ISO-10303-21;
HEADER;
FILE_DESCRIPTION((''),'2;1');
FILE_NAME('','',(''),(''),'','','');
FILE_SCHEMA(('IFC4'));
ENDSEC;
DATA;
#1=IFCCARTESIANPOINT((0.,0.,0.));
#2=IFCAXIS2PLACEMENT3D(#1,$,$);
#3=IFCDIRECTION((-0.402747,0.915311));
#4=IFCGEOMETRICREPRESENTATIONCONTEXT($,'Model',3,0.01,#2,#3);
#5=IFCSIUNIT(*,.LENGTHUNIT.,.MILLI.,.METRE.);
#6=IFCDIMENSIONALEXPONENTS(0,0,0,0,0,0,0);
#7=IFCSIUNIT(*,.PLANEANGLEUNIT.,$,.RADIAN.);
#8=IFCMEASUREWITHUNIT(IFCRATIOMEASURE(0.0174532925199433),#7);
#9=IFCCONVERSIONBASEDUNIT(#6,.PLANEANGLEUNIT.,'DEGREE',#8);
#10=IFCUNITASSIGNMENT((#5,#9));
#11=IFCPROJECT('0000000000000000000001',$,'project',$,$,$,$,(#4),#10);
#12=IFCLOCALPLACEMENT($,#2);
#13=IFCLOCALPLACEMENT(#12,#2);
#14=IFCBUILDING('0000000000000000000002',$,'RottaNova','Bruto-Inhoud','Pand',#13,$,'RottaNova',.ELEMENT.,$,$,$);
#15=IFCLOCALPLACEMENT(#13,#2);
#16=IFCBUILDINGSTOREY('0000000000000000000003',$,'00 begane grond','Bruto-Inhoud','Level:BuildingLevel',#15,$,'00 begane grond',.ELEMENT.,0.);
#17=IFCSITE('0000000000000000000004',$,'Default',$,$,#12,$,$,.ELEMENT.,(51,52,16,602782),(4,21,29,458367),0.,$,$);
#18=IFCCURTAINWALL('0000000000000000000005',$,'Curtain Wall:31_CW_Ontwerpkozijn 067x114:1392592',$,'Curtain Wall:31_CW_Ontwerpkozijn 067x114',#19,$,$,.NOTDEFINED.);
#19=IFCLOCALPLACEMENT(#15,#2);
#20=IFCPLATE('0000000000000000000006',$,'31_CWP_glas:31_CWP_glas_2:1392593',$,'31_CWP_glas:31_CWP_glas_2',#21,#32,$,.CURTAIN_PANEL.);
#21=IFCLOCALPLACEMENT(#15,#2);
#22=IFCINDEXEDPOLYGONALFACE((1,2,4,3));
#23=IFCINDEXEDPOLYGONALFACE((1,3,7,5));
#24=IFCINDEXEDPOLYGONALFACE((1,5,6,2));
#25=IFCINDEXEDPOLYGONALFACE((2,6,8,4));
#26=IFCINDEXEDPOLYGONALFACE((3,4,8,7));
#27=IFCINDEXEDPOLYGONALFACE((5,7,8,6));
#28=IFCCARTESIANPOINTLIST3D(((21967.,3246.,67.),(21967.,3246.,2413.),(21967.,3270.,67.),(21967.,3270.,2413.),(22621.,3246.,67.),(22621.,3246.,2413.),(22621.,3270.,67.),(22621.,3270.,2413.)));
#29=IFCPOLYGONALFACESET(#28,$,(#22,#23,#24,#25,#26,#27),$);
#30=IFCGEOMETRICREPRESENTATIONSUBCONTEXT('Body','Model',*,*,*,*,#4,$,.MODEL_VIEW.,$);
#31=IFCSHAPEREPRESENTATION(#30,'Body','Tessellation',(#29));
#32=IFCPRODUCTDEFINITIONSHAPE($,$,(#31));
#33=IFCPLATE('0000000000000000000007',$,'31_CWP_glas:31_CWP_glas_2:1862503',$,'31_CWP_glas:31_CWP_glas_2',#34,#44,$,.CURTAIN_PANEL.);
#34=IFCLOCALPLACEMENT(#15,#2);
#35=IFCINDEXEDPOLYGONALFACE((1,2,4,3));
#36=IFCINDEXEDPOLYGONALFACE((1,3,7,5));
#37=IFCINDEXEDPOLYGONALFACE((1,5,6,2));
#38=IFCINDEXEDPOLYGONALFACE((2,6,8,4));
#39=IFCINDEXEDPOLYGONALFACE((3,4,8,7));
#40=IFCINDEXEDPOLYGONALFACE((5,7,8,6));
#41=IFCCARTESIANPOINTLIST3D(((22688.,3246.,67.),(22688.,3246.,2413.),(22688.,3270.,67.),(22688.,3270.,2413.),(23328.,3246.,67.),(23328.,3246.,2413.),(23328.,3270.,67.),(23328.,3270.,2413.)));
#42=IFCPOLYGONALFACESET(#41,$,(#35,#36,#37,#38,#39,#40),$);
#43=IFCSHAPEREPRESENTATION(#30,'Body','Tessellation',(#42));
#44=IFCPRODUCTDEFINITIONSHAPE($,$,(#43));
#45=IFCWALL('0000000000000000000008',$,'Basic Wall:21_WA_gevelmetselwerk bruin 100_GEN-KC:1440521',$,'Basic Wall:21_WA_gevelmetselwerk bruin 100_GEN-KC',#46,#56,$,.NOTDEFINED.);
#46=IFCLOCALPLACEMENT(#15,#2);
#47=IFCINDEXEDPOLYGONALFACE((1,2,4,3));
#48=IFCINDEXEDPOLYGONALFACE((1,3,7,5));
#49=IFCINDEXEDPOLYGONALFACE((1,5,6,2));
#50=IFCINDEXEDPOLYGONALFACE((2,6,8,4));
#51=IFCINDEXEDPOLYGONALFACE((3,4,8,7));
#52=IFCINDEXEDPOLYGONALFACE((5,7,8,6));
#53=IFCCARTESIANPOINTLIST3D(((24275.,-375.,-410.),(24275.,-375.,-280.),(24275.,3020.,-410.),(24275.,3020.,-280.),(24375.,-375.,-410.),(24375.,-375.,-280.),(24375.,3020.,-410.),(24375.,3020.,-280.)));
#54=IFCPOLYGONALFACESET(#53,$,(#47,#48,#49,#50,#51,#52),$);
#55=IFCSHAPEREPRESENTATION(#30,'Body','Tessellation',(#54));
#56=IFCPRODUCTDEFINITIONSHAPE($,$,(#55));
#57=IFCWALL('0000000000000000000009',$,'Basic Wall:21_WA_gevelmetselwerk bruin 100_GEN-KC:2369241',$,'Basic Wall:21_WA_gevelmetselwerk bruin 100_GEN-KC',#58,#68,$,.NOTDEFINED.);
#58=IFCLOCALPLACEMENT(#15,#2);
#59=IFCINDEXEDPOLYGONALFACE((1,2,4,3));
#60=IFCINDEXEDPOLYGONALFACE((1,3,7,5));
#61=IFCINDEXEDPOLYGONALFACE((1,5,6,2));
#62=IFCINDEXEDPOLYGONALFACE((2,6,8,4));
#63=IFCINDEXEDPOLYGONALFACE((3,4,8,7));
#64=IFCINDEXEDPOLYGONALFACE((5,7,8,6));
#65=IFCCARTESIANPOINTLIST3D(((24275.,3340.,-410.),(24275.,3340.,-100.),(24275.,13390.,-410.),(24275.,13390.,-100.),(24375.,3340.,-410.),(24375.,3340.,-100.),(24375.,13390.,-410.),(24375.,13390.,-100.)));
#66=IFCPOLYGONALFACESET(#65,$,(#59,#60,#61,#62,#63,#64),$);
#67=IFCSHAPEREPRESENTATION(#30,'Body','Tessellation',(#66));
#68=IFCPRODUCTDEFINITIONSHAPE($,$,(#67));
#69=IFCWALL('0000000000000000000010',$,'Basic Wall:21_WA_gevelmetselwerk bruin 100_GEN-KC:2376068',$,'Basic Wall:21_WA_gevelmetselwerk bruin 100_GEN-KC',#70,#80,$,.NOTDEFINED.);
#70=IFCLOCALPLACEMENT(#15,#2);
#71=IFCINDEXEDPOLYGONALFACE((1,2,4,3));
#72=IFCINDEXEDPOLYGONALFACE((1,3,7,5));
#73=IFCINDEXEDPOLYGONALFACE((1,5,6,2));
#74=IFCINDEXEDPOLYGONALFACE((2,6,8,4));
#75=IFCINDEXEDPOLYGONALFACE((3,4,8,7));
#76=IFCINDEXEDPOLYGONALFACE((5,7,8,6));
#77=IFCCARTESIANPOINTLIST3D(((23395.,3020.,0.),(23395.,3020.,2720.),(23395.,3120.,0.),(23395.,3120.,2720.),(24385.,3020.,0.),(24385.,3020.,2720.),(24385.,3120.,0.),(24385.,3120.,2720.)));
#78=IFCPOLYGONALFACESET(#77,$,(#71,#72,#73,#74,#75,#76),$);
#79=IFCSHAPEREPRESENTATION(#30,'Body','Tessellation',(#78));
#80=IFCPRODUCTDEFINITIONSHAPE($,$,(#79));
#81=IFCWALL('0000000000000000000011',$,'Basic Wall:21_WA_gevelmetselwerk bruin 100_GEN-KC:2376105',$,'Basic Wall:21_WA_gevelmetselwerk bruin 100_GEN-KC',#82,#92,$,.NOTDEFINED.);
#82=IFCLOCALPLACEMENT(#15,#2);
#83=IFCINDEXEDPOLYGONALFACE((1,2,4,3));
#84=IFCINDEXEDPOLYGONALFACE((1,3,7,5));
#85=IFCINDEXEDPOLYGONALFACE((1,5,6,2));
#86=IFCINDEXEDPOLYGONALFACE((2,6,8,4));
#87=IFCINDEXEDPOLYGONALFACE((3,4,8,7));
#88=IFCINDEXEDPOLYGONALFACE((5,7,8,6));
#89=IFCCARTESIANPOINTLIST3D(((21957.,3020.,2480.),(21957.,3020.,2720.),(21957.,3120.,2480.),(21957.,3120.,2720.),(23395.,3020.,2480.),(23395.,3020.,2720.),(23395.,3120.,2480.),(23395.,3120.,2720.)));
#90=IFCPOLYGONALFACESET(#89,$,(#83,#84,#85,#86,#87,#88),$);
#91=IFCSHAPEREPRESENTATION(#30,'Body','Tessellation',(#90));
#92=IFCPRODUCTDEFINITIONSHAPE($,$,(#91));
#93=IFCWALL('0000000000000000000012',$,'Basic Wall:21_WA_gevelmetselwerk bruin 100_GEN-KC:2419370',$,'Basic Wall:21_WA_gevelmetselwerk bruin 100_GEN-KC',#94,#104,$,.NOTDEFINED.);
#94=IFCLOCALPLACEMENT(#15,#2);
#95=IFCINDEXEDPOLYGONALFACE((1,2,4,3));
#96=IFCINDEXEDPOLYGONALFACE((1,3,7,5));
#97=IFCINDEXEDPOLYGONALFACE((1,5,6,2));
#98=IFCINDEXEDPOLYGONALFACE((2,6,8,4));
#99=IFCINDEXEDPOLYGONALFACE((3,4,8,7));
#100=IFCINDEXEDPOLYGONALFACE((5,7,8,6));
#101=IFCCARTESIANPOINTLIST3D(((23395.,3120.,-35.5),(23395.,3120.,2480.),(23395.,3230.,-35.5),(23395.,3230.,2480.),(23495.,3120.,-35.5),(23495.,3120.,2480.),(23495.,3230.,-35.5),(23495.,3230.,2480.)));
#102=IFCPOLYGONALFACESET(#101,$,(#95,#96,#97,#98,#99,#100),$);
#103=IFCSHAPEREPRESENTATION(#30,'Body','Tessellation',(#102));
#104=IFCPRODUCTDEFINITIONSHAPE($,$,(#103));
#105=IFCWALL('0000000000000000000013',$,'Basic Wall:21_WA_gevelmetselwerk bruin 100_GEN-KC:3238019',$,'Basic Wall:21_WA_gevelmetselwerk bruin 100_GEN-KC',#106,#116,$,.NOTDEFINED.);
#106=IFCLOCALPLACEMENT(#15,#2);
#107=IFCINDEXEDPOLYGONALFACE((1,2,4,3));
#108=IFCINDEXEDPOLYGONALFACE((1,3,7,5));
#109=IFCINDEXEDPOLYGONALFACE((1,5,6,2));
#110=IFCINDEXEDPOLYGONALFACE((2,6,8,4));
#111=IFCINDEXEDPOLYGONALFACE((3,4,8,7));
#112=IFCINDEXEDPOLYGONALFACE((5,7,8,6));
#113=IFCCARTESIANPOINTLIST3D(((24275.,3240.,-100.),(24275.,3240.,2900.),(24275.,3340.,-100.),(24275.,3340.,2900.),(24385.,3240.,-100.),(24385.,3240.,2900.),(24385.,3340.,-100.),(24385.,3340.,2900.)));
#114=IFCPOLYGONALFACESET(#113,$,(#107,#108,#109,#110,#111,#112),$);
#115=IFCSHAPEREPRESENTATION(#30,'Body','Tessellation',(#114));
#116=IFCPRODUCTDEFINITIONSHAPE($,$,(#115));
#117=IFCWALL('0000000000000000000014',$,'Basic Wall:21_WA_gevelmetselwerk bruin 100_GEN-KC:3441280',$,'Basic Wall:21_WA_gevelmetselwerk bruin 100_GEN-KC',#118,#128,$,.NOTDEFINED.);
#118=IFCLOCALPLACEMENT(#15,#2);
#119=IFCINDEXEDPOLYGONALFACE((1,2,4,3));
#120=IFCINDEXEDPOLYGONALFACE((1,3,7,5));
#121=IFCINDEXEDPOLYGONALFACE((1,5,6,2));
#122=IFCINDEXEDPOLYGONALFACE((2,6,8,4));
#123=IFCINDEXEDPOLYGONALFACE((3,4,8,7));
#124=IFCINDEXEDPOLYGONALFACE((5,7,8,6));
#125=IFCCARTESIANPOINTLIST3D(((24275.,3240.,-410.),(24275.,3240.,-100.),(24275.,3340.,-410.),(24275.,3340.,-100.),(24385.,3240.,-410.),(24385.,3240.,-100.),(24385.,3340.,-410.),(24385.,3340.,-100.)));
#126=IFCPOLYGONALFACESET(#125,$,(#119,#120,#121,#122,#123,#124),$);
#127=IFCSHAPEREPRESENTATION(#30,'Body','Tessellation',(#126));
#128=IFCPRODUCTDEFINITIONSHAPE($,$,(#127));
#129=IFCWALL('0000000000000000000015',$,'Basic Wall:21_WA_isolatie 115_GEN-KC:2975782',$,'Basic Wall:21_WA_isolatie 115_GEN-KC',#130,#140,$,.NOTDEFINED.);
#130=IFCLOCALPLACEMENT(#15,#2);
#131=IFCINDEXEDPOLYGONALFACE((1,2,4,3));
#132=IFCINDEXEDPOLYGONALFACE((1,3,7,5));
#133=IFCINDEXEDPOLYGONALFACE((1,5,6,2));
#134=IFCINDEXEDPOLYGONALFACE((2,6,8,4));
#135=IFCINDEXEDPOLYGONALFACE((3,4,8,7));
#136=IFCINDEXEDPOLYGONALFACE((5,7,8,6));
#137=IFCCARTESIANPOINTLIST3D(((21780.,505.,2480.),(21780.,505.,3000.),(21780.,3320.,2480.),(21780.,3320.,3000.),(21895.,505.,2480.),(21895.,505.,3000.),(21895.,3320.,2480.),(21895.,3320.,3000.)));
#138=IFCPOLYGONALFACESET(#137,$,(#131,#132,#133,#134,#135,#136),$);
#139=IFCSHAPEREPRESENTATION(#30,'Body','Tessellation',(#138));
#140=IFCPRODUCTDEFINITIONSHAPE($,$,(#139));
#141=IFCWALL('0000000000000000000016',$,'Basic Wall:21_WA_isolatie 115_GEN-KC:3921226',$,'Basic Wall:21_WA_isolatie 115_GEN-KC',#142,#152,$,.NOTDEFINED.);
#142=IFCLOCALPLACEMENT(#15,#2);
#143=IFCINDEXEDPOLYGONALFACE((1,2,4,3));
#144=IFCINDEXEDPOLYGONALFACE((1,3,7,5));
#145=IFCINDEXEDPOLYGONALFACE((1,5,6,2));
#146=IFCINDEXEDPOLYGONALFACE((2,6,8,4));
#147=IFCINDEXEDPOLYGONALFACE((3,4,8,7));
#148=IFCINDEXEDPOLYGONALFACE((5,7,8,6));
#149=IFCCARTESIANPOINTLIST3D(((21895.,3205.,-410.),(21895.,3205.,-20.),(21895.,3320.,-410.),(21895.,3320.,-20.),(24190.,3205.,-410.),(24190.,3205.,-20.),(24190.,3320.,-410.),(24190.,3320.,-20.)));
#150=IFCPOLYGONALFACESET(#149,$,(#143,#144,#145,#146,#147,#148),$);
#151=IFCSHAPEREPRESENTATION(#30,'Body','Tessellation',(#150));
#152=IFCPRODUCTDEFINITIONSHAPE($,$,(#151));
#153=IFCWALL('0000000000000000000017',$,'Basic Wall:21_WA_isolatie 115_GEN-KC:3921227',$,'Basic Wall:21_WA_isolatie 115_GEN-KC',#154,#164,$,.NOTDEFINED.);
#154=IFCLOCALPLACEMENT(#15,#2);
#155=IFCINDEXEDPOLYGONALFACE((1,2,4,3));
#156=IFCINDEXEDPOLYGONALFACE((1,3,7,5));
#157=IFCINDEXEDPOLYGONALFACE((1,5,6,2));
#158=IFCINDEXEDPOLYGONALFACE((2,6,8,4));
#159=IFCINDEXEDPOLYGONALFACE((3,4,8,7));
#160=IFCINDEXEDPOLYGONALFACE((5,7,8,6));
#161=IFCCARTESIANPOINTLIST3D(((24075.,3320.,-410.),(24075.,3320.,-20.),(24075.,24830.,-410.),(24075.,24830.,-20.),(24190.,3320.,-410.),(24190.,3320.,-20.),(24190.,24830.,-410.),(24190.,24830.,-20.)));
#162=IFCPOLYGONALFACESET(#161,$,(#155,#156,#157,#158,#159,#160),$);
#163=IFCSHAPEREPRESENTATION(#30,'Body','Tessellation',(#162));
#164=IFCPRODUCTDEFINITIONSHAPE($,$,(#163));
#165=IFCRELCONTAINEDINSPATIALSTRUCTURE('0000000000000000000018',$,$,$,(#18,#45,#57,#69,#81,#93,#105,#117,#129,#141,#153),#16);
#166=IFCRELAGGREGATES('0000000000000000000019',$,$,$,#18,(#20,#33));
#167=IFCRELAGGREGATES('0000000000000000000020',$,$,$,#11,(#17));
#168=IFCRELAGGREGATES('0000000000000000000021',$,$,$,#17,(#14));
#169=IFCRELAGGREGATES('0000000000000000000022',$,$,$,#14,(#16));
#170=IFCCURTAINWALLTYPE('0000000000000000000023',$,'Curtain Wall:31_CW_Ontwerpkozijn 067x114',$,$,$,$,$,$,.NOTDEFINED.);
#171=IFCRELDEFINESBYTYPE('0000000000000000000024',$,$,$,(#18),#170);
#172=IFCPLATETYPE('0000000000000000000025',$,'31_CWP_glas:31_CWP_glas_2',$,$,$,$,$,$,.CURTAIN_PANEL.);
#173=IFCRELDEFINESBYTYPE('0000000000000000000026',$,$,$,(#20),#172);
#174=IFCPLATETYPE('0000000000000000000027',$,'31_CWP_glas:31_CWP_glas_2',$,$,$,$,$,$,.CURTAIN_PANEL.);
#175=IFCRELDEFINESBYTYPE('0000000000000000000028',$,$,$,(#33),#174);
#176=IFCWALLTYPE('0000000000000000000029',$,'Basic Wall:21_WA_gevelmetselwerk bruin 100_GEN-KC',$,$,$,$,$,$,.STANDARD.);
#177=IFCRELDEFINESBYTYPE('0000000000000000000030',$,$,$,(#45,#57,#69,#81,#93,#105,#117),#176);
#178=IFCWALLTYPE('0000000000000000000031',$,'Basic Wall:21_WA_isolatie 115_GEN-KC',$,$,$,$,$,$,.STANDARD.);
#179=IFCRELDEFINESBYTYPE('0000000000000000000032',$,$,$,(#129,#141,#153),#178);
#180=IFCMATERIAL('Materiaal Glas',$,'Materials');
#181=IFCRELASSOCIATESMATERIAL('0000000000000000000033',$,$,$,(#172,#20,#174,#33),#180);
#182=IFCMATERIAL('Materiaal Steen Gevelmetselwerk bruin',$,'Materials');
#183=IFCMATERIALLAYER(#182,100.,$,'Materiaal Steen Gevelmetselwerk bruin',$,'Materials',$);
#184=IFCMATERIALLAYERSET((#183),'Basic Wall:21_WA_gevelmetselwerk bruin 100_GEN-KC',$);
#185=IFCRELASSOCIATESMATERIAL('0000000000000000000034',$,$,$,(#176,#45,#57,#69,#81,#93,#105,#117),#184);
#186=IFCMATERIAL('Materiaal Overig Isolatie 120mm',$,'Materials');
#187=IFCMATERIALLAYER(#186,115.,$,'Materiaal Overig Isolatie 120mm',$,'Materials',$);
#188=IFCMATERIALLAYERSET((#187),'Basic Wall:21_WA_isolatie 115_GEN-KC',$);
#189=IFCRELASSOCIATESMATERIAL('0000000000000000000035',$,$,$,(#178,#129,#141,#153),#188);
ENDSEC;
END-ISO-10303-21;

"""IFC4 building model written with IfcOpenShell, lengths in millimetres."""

from ifc_helpers import new_model, entity, si_unit, converted_unit, direction, frame, frame_2d, origin, place, context, subcontext, project, spatial, rectangle, extrude, source, transform, mapped, material, layer, layer_set, type_object, type_shapes, element, aggregate, save


model = new_model("IFC4")

# Units and contexts
model_context = context("Model", 3, precision=0.01, world=origin(), true_north=direction((-0.402747, 0.915311)))
body_context = subcontext(model_context, "Body", "Model", "MODEL_VIEW")
ifc_project = project(units=[si_unit("LENGTHUNIT", "METRE", prefix="MILLI"), converted_unit("PLANEANGLEUNIT", "DEGREE", entity("IfcRatioMeasure", 0.0174532925199433), si_unit("PLANEANGLEUNIT", "RADIAN"), dimensions=[0, 0, 0, 0, 0, 0, 0])], contexts=[model_context])

# Site, building, storey
site_placement = place(None, origin())
site = spatial("IfcSite", under=ifc_project, at=site_placement, Name="Default", CompositionType="ELEMENT", RefLatitude=(51, 52, 16, 602782), RefLongitude=(4, 21, 29, 458367), RefElevation=0.0)
building_placement = place(site_placement, origin())
building = spatial("IfcBuilding", under=site, at=building_placement, Name="RottaNova", Description="Bruto-Inhoud", ObjectType="Pand", LongName="RottaNova", CompositionType="ELEMENT")
storey_placement = place(building_placement, origin())
storey = spatial("IfcBuildingStorey", under=building, at=storey_placement, Name="00 begane grond", Description="Bruto-Inhoud", ObjectType="Level:BuildingLevel", LongName="00 begane grond", CompositionType="ELEMENT", Elevation=0.0)

# Curtain wall
curtain_wall_type = type_object("IfcCurtainWallType", Name="Curtain Wall:31_CW_Ontwerpkozijn 067x114", PredefinedType="NOTDEFINED")
curtain_wall_1_placement = place(storey_placement, origin())
curtain_wall_1 = element("IfcCurtainWall", 1, at=curtain_wall_1_placement, inside=storey, type_object=curtain_wall_type, Name="Curtain Wall:31_CW_Ontwerpkozijn 067x114:1392592", ObjectType="Curtain Wall:31_CW_Ontwerpkozijn 067x114", PredefinedType="NOTDEFINED")

# Plates
ifc_material_1 = material(Name="Materiaal Glas", Category="Materials")
plate_type_1 = type_object("IfcPlateType", Name="31_CWP_glas:31_CWP_glas_2", PredefinedType="CURTAIN_PANEL", material=ifc_material_1)
shared_shape_1 = source(origin(), body_context, "Body", "SweptSolid", [
    extrude(rectangle(XDim=24.0, YDim=654.0, at=frame_2d((0.0, 0.0), x_axis=(1.0, 0.0))), frame((327.0, 12.0, 0.0), z_axis=(0.0, 0.0, 1.0), x_axis=(0.0, 1.0, 0.0)), (0.0, 0.0, 1.0), 2346.0),
])
type_shapes(plate_type_1, [shared_shape_1])
plate_1_placement = place(curtain_wall_1_placement, frame((21967.0, 3246.0, 67.0)))
plate_1 = element("IfcPlate", 2, at=plate_1_placement, type_object=plate_type_1, material=ifc_material_1, Name="31_CWP_glas:31_CWP_glas_2:1392593", ObjectType="31_CWP_glas:31_CWP_glas_2", PredefinedType="CURTAIN_PANEL", context=body_context, shape_type="MappedRepresentation", body=[
    mapped(shared_shape_1, transform((0.0, 0.0, 0.0), scale=1.0)),
])
plate_type_2 = type_object("IfcPlateType", Name="31_CWP_glas:31_CWP_glas_2", PredefinedType="CURTAIN_PANEL", material=ifc_material_1)
shared_shape_2 = source(origin(), body_context, "Body", "SweptSolid", [
    extrude(rectangle(XDim=24.0, YDim=640.0, at=frame_2d((0.0, 0.0), x_axis=(1.0, 0.0))), frame((320.0, 12.0, 0.0), z_axis=(0.0, 0.0, 1.0), x_axis=(0.0, 1.0, 0.0)), (0.0, 0.0, 1.0), 2346.0),
])
type_shapes(plate_type_2, [shared_shape_2])
plate_2_placement = place(curtain_wall_1_placement, frame((22688.0, 3246.0, 67.0)))
plate_2 = element("IfcPlate", 3, at=plate_2_placement, type_object=plate_type_2, material=ifc_material_1, Name="31_CWP_glas:31_CWP_glas_2:1862503", ObjectType="31_CWP_glas:31_CWP_glas_2", PredefinedType="CURTAIN_PANEL", context=body_context, shape_type="MappedRepresentation", body=[
    mapped(shared_shape_2, transform((0.0, 0.0, 0.0), scale=1.0)),
])
aggregate(curtain_wall_1, [plate_1, plate_2])

# Walls
ifc_material_2 = material(Name="Materiaal Steen Gevelmetselwerk bruin", Category="Materials")
ifc_layer_1 = layer(ifc_material_2, 100.0, Name="Materiaal Steen Gevelmetselwerk bruin", Category="Materials")
ifc_layer_set_1 = layer_set([ifc_layer_1], Name="Basic Wall:21_WA_gevelmetselwerk bruin 100_GEN-KC")
wall_type_1 = type_object("IfcWallType", Name="Basic Wall:21_WA_gevelmetselwerk bruin 100_GEN-KC", PredefinedType="STANDARD", material=ifc_layer_set_1)
wall_1_placement = place(storey_placement, frame((24325.0, 3020.0, -410.0), z_axis=(0.0, 0.0, 1.0), x_axis=(0.0, -1.0, 0.0)))
element("IfcWall", 4, at=wall_1_placement, inside=storey, type_object=wall_type_1, material=ifc_layer_set_1, Name="Basic Wall:21_WA_gevelmetselwerk bruin 100_GEN-KC:1440521", ObjectType="Basic Wall:21_WA_gevelmetselwerk bruin 100_GEN-KC", PredefinedType="NOTDEFINED", context=body_context, shape_type="SweptSolid", body=[
    extrude(rectangle(XDim=3395.0, YDim=100.0, at=frame_2d((1697.5, 0.0), x_axis=(-1.0, 0.0))), origin(), (0.0, 0.0, 1.0), 130.0),
])
wall_2_placement = place(storey_placement, frame((24325.0, 3340.0, -410.0), z_axis=(0.0, 0.0, 1.0), x_axis=(0.0, 1.0, 0.0)))
element("IfcWall", 5, at=wall_2_placement, inside=storey, type_object=wall_type_1, material=ifc_layer_set_1, Name="Basic Wall:21_WA_gevelmetselwerk bruin 100_GEN-KC:2369241", ObjectType="Basic Wall:21_WA_gevelmetselwerk bruin 100_GEN-KC", PredefinedType="NOTDEFINED", context=body_context, shape_type="SweptSolid", body=[
    extrude(rectangle(XDim=10050.0, YDim=100.0, at=frame_2d((5025.0, 0.0), x_axis=(-1.0, 0.0))), origin(), (0.0, 0.0, 1.0), 310.0),
])
wall_3_placement = place(storey_placement, frame((23395.0, 3070.0, 0.0)))
element("IfcWall", 6, at=wall_3_placement, inside=storey, type_object=wall_type_1, material=ifc_layer_set_1, Name="Basic Wall:21_WA_gevelmetselwerk bruin 100_GEN-KC:2376068", ObjectType="Basic Wall:21_WA_gevelmetselwerk bruin 100_GEN-KC", PredefinedType="NOTDEFINED", context=body_context, shape_type="SweptSolid", body=[
    extrude(rectangle(XDim=990.0, YDim=100.0, at=frame_2d((495.0, 0.0), x_axis=(-1.0, 0.0))), origin(), (0.0, 0.0, 1.0), 2720.0),
])
wall_4_placement = place(storey_placement, frame((23395.0, 3070.0, 2480.0), z_axis=(0.0, 0.0, 1.0), x_axis=(-1.0, 0.0, 0.0)))
element("IfcWall", 7, at=wall_4_placement, inside=storey, type_object=wall_type_1, material=ifc_layer_set_1, Name="Basic Wall:21_WA_gevelmetselwerk bruin 100_GEN-KC:2376105", ObjectType="Basic Wall:21_WA_gevelmetselwerk bruin 100_GEN-KC", PredefinedType="NOTDEFINED", context=body_context, shape_type="SweptSolid", body=[
    extrude(rectangle(XDim=1438.0, YDim=100.0, at=frame_2d((719.0, 0.0), x_axis=(-1.0, 0.0))), origin(), (0.0, 0.0, 1.0), 240.0),
])
wall_5_placement = place(storey_placement, frame((23445.0, 3230.0, -35.5), z_axis=(0.0, 0.0, 1.0), x_axis=(0.0, -1.0, 0.0)))
element("IfcWall", 8, at=wall_5_placement, inside=storey, type_object=wall_type_1, material=ifc_layer_set_1, Name="Basic Wall:21_WA_gevelmetselwerk bruin 100_GEN-KC:2419370", ObjectType="Basic Wall:21_WA_gevelmetselwerk bruin 100_GEN-KC", PredefinedType="NOTDEFINED", context=body_context, shape_type="SweptSolid", body=[
    extrude(rectangle(XDim=110.0, YDim=100.0, at=frame_2d((55.0, 0.0), x_axis=(-1.0, 0.0))), origin(), (0.0, 0.0, 1.0), 2515.5),
])
wall_6_placement = place(storey_placement, frame((24385.0, 3290.0, -100.0), z_axis=(0.0, 0.0, 1.0), x_axis=(-1.0, 0.0, 0.0)))
element("IfcWall", 9, at=wall_6_placement, inside=storey, type_object=wall_type_1, material=ifc_layer_set_1, Name="Basic Wall:21_WA_gevelmetselwerk bruin 100_GEN-KC:3238019", ObjectType="Basic Wall:21_WA_gevelmetselwerk bruin 100_GEN-KC", PredefinedType="NOTDEFINED", context=body_context, shape_type="SweptSolid", body=[
    extrude(rectangle(XDim=110.0, YDim=100.0, at=frame_2d((55.0, 0.0), x_axis=(-1.0, 0.0))), origin(), (0.0, 0.0, 1.0), 3000.0),
])
wall_7_placement = place(storey_placement, frame((24385.0, 3290.0, -410.0), z_axis=(0.0, 0.0, 1.0), x_axis=(-1.0, 0.0, 0.0)))
element("IfcWall", 10, at=wall_7_placement, inside=storey, type_object=wall_type_1, material=ifc_layer_set_1, Name="Basic Wall:21_WA_gevelmetselwerk bruin 100_GEN-KC:3441280", ObjectType="Basic Wall:21_WA_gevelmetselwerk bruin 100_GEN-KC", PredefinedType="NOTDEFINED", context=body_context, shape_type="SweptSolid", body=[
    extrude(rectangle(XDim=110.0, YDim=100.0, at=frame_2d((55.0, 0.0), x_axis=(-1.0, 0.0))), origin(), (0.0, 0.0, 1.0), 310.0),
])

# Shared definitions
ifc_material_3 = material(Name="Materiaal Overig Isolatie 120mm", Category="Materials")
ifc_layer_2 = layer(ifc_material_3, 115.0, Name="Materiaal Overig Isolatie 120mm", Category="Materials")
ifc_layer_set_2 = layer_set([ifc_layer_2], Name="Basic Wall:21_WA_isolatie 115_GEN-KC")
wall_type_2 = type_object("IfcWallType", Name="Basic Wall:21_WA_isolatie 115_GEN-KC", PredefinedType="STANDARD", material=ifc_layer_set_2)

# Walls
wall_8_placement = place(storey_placement, frame((21837.5, 3320.0, 2480.0), z_axis=(0.0, 0.0, 1.0), x_axis=(0.0, -1.0, 0.0)))
element("IfcWall", 11, at=wall_8_placement, inside=storey, type_object=wall_type_2, material=ifc_layer_set_2, Name="Basic Wall:21_WA_isolatie 115_GEN-KC:2975782", ObjectType="Basic Wall:21_WA_isolatie 115_GEN-KC", PredefinedType="NOTDEFINED", context=body_context, shape_type="SweptSolid", body=[
    extrude(rectangle(XDim=2815.0, YDim=115.0, at=frame_2d((1407.5, 0.0), x_axis=(-1.0, 0.0))), origin(), (0.0, 0.0, 1.0), 520.0),
])
wall_9_placement = place(storey_placement, frame((21895.0, 3262.5, -410.0)))
element("IfcWall", 12, at=wall_9_placement, inside=storey, type_object=wall_type_2, material=ifc_layer_set_2, Name="Basic Wall:21_WA_isolatie 115_GEN-KC:3921226", ObjectType="Basic Wall:21_WA_isolatie 115_GEN-KC", PredefinedType="NOTDEFINED", context=body_context, shape_type="SweptSolid", body=[
    extrude(rectangle(XDim=2295.0, YDim=115.0, at=frame_2d((1147.5, 0.0), x_axis=(-1.0, 0.0))), origin(), (0.0, 0.0, 1.0), 390.0),
])
wall_10_placement = place(storey_placement, frame((24132.5, 3320.0, -410.0), z_axis=(0.0, 0.0, 1.0), x_axis=(0.0, 1.0, 0.0)))
element("IfcWall", 13, at=wall_10_placement, inside=storey, type_object=wall_type_2, material=ifc_layer_set_2, Name="Basic Wall:21_WA_isolatie 115_GEN-KC:3921227", ObjectType="Basic Wall:21_WA_isolatie 115_GEN-KC", PredefinedType="NOTDEFINED", context=body_context, shape_type="SweptSolid", body=[
    extrude(rectangle(XDim=21510.0, YDim=115.0, at=frame_2d((10755.0, 0.0), x_axis=(-1.0, 0.0))), origin(), (0.0, 0.0, 1.0), 390.0),
])

save(model, "model.ifc")
